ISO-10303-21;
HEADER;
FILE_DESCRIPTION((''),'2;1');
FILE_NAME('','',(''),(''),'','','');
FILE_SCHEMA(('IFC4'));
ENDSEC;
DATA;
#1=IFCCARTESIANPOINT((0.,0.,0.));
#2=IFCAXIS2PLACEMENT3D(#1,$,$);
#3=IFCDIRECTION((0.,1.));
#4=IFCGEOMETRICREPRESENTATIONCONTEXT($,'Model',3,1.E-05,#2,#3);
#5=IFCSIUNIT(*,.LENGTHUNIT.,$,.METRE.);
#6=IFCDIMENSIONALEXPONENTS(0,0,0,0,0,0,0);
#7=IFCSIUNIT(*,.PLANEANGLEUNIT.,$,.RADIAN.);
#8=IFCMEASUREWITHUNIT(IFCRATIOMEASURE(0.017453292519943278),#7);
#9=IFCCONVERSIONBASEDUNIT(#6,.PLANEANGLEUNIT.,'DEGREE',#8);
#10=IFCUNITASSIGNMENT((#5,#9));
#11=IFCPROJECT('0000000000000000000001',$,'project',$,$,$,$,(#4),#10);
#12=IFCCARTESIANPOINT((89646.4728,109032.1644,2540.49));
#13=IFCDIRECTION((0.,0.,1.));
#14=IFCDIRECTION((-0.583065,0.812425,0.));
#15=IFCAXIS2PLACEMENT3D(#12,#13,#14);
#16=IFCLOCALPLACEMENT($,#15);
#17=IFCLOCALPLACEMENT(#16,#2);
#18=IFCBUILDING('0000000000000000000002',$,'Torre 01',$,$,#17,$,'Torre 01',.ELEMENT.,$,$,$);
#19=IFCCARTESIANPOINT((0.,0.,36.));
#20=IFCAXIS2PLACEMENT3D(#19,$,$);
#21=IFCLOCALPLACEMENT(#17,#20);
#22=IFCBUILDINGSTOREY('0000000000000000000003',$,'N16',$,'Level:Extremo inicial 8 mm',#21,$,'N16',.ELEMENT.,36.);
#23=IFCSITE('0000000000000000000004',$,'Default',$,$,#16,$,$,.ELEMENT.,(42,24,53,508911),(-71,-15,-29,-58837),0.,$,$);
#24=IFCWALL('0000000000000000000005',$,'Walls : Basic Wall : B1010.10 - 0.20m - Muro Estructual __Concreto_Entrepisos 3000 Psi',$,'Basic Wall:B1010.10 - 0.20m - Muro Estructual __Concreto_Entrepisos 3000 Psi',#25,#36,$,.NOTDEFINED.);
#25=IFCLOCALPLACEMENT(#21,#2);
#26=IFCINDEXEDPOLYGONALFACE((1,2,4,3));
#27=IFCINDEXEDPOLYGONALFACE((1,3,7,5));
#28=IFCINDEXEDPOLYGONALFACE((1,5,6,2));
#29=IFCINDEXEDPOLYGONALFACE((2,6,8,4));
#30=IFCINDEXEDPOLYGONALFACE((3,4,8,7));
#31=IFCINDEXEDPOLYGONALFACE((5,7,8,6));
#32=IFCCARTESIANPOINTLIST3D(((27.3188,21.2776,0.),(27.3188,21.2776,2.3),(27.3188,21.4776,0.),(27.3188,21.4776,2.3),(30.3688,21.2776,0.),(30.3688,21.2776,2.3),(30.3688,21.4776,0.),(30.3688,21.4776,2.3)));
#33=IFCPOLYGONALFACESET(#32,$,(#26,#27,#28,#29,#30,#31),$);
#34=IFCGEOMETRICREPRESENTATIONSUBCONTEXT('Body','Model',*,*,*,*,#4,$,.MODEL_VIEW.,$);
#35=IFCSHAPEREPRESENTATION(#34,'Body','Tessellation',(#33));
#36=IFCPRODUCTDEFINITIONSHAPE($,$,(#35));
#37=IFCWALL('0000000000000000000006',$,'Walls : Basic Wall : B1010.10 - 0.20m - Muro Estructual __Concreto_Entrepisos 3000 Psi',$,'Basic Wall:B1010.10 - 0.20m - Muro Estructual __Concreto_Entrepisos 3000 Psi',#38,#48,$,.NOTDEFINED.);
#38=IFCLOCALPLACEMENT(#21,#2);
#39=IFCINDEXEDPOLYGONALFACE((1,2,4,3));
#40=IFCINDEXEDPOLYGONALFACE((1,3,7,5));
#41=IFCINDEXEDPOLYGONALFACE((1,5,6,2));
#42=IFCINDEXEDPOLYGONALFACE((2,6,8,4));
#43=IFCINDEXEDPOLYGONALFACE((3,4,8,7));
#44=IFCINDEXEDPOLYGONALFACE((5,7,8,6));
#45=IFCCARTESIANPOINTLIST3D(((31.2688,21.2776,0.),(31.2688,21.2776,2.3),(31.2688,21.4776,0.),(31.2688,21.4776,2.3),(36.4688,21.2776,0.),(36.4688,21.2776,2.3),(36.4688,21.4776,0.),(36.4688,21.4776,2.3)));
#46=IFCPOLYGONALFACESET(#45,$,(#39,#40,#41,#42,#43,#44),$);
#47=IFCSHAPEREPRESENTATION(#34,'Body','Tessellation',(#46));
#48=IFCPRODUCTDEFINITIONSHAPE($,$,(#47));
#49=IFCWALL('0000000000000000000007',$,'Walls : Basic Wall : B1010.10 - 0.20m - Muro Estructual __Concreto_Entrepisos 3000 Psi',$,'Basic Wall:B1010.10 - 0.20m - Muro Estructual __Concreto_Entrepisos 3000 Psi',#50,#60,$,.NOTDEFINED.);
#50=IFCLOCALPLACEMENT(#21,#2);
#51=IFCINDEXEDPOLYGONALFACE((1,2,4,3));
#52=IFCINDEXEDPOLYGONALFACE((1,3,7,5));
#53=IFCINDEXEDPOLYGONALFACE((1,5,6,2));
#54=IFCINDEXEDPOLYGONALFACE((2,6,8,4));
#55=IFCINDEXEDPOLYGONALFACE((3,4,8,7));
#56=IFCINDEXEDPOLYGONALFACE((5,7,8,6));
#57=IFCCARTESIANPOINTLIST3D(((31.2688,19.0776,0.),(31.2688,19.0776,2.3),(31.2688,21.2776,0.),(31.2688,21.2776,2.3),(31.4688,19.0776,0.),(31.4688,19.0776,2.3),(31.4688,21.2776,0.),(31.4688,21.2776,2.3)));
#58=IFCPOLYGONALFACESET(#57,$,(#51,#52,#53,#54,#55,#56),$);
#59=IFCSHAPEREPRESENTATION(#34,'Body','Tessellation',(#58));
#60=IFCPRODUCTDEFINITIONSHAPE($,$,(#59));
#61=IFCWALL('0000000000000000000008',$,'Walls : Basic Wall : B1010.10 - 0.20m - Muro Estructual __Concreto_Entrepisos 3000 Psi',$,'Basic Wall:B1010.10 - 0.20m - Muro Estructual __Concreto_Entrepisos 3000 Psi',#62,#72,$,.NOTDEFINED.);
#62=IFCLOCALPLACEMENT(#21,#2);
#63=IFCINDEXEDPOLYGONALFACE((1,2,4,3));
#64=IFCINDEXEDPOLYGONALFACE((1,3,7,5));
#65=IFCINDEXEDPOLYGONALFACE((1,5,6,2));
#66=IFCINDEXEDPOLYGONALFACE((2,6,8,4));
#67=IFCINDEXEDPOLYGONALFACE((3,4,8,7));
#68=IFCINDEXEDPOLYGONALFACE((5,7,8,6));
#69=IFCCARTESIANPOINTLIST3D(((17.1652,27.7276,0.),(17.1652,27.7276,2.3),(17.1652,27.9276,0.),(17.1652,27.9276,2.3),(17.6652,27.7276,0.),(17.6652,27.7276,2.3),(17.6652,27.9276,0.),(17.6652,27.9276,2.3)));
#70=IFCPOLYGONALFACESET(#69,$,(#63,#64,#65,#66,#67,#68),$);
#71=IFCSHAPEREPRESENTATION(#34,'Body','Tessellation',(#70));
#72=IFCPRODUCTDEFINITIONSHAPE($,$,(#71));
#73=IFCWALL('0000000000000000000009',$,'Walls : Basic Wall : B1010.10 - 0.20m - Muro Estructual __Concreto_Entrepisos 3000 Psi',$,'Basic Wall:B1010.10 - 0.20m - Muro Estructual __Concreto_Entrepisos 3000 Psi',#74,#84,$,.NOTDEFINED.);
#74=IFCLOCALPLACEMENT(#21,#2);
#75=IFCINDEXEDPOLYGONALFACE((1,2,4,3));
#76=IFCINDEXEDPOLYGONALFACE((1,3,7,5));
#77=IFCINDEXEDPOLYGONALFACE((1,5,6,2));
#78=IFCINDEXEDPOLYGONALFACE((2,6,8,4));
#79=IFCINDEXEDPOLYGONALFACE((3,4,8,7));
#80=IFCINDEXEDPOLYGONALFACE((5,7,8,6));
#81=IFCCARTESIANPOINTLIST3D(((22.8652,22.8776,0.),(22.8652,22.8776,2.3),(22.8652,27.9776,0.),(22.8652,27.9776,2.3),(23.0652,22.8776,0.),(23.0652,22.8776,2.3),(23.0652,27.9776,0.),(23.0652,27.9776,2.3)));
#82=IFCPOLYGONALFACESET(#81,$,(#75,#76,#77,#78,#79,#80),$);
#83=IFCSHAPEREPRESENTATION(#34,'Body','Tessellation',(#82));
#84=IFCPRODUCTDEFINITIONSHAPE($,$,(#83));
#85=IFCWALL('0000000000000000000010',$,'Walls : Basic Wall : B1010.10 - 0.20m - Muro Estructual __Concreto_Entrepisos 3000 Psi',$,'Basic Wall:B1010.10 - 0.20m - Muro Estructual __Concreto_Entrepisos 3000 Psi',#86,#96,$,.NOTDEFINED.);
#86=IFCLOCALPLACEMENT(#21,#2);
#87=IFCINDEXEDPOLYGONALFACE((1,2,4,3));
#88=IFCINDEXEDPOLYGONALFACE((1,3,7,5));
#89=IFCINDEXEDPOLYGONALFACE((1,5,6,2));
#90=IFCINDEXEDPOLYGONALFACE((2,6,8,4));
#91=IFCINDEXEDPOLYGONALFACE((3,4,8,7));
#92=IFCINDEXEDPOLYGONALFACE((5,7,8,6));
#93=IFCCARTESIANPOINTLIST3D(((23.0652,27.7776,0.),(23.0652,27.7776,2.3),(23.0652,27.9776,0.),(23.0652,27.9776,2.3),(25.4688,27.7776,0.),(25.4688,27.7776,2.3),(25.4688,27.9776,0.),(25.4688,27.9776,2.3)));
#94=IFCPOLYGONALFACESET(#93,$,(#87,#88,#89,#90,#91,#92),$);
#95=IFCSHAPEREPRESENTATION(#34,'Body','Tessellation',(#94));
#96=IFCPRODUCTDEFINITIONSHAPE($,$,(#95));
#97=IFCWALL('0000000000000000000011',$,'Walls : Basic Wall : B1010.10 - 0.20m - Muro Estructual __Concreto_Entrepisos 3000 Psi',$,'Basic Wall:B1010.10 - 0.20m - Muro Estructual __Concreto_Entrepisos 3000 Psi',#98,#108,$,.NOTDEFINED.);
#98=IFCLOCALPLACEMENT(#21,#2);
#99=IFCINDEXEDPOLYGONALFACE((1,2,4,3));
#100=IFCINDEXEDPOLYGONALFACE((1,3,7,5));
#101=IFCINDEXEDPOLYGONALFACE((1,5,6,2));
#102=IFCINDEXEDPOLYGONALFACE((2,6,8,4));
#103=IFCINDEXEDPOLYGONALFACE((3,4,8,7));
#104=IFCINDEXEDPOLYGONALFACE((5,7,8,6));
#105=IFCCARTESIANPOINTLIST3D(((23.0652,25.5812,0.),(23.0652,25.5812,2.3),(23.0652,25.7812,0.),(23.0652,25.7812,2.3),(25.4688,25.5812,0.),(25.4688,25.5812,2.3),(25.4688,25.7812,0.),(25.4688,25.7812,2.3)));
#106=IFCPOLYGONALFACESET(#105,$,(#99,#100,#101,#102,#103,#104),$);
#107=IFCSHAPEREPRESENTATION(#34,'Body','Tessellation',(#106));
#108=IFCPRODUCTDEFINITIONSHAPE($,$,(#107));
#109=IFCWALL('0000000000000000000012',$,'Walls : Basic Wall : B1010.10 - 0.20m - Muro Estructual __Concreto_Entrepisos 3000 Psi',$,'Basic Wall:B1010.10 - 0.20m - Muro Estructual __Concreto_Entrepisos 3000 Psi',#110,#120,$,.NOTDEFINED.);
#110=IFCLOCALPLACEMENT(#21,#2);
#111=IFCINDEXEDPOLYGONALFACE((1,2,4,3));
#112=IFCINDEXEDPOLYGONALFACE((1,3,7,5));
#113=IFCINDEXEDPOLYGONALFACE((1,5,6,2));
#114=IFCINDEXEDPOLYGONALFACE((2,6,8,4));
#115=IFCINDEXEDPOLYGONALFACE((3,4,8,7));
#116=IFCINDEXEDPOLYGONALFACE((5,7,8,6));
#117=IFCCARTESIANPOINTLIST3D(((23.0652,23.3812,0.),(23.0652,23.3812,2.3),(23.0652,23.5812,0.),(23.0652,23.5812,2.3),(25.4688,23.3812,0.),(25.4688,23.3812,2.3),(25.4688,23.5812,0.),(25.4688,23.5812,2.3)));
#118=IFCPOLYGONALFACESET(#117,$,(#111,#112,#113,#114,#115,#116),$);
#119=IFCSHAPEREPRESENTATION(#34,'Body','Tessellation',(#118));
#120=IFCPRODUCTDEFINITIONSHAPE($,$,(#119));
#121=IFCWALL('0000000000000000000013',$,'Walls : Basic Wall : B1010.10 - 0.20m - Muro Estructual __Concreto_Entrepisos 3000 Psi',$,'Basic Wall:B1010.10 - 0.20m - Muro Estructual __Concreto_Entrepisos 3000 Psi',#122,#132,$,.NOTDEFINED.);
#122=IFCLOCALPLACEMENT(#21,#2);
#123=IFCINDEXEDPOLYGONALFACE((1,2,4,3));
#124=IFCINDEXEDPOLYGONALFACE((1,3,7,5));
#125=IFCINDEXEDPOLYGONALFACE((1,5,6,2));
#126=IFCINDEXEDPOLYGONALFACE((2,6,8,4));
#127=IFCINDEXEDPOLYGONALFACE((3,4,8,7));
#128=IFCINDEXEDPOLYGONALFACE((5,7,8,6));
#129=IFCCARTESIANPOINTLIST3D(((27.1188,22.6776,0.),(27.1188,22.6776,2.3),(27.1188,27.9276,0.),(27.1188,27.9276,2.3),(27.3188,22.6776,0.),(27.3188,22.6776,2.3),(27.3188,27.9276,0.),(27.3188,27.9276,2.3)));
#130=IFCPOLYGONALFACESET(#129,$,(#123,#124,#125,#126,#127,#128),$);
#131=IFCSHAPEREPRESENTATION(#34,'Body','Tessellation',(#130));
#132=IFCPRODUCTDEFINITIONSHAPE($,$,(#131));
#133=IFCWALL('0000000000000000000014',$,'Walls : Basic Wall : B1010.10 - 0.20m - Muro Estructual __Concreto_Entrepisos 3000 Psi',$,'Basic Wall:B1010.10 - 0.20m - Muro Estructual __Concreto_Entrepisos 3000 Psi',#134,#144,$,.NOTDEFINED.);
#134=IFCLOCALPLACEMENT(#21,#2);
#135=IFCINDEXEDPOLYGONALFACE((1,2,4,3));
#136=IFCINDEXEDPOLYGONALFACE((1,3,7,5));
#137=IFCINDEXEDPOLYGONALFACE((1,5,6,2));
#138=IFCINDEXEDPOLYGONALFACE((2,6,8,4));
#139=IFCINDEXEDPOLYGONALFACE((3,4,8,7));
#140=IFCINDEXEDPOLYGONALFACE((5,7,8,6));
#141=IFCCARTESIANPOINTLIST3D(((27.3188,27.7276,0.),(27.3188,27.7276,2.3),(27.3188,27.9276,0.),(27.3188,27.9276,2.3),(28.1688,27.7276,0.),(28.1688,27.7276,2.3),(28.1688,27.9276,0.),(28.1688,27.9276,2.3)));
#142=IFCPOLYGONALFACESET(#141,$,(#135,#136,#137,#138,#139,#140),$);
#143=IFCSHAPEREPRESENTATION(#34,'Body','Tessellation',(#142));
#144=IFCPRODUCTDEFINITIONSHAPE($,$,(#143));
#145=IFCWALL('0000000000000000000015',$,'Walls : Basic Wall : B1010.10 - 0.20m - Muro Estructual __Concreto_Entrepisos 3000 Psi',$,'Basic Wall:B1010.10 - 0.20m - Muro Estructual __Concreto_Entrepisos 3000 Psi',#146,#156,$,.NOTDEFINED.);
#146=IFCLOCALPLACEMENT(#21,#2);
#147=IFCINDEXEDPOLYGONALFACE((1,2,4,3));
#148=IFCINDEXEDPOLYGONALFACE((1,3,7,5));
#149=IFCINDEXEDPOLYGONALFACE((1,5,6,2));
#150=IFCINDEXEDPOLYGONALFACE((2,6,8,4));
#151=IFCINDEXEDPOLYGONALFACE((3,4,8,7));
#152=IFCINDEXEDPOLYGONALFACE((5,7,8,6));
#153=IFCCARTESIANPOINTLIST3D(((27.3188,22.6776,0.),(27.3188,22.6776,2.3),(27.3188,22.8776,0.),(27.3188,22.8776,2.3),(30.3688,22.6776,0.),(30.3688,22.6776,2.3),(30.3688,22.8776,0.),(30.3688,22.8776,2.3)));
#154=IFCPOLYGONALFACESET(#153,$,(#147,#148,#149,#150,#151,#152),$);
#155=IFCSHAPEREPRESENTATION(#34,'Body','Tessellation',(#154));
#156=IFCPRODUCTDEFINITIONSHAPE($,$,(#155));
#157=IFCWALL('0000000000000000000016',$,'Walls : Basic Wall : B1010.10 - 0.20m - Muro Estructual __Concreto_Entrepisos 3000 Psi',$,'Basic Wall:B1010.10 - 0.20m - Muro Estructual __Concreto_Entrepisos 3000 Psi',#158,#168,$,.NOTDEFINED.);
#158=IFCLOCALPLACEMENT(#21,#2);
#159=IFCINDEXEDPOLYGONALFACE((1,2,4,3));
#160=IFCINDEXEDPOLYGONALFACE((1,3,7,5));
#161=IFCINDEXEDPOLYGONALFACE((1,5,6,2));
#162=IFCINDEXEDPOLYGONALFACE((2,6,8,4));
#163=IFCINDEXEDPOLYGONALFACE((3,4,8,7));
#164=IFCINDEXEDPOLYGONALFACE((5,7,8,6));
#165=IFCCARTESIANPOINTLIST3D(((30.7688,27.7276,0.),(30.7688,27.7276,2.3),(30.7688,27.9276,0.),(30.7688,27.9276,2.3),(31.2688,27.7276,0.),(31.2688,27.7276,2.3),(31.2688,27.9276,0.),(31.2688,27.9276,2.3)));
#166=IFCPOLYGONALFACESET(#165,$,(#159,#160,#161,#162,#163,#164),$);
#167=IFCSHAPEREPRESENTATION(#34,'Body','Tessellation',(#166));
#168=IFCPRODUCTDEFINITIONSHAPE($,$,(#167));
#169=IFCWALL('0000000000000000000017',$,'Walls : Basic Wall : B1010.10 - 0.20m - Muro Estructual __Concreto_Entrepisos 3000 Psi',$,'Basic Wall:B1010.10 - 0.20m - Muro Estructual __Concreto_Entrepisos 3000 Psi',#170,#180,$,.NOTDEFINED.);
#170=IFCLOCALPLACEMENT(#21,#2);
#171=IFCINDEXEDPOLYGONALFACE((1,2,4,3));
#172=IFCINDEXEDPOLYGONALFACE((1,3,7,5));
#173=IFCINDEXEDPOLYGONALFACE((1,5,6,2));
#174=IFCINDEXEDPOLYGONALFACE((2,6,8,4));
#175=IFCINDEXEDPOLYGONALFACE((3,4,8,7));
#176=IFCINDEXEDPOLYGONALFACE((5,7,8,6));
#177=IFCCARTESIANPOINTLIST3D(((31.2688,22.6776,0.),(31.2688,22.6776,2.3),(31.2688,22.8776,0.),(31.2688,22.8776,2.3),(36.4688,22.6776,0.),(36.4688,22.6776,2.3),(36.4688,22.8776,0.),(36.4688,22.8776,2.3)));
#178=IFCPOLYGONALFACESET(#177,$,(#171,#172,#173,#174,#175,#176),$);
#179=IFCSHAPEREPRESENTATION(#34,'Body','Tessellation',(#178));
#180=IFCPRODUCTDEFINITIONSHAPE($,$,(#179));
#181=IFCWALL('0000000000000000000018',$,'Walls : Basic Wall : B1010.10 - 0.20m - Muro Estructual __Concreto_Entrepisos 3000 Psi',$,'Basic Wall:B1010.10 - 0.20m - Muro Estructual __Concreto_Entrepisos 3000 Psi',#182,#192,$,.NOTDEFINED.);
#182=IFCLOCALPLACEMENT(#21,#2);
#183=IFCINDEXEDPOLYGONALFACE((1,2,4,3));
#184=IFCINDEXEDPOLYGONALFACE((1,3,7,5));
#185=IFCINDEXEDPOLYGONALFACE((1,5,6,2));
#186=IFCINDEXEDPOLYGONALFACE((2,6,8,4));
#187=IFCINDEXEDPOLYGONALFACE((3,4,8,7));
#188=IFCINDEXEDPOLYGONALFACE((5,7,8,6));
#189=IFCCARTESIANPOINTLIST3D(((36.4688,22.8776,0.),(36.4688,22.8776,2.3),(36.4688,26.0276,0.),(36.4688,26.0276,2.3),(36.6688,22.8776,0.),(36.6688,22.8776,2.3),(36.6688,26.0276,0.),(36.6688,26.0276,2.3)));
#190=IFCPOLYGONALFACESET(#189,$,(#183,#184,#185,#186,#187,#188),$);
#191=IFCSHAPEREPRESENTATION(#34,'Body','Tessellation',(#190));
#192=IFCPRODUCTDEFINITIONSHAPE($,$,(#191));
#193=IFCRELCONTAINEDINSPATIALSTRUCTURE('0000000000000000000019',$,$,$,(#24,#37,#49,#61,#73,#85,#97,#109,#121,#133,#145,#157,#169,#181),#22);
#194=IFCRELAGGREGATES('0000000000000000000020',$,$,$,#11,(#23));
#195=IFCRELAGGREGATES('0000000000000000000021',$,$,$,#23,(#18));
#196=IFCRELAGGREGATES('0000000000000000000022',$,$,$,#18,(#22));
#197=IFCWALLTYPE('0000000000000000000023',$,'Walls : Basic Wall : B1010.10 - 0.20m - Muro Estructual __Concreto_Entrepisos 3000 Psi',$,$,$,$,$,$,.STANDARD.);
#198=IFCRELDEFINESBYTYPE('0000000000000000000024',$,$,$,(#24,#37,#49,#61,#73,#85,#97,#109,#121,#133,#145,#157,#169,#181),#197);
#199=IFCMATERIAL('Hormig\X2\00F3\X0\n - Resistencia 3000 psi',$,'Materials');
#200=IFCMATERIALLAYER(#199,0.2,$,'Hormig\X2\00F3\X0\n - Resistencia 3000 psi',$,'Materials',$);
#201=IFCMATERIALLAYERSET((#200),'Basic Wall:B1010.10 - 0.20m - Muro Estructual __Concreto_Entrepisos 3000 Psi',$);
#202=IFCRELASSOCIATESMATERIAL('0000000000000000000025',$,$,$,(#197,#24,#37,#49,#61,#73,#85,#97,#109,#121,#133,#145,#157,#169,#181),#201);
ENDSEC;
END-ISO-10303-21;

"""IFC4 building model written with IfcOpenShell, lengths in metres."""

from ifc_helpers import new_model, entity, si_unit, converted_unit, direction, frame, frame_2d, origin, place, context, subcontext, project, spatial, rectangle, extrude, material, layer, layer_set, layer_usage, type_object, element, save


model = new_model("IFC4")

# Units and contexts
model_context = context("Model", 3, precision=1e-05, world=origin(), true_north=direction((0.0, 1.0)))
body_context = subcontext(model_context, "Body", "Model", "MODEL_VIEW")
ifc_project = project(units=[si_unit("LENGTHUNIT", "METRE"), converted_unit("PLANEANGLEUNIT", "DEGREE", entity("IfcRatioMeasure", 0.017453292519943278), si_unit("PLANEANGLEUNIT", "RADIAN"), dimensions=[0, 0, 0, 0, 0, 0, 0])], contexts=[model_context])

# Site, building, storey
site_placement = place(None, frame((89646.4728, 109032.1644, 2540.49), z_axis=(0.0, 0.0, 1.0), x_axis=(-0.583065, 0.812425, 0.0)))
site = spatial("IfcSite", under=ifc_project, at=site_placement, Name="Default", CompositionType="ELEMENT", RefLatitude=(42, 24, 53, 508911), RefLongitude=(-71, -15, -29, -58837), RefElevation=0.0)
building_placement = place(site_placement, origin())
building = spatial("IfcBuilding", under=site, at=building_placement, Name="Torre 01", LongName="Torre 01", CompositionType="ELEMENT")
storey_placement = place(building_placement, frame((0.0, 0.0, 36.0)))
storey = spatial("IfcBuildingStorey", under=building, at=storey_placement, Name="N16", ObjectType="Level:Extremo inicial 8 mm", LongName="N16", CompositionType="ELEMENT", Elevation=36.0)

# Walls
ifc_material = material(Name="Hormigón - Resistencia 3000 psi", Category="Materials")
ifc_layer_1 = layer(ifc_material, 0.2, Name="Hormigón - Resistencia 3000 psi", Category="Materials")
ifc_layer_set_1 = layer_set([ifc_layer_1], Name="Basic Wall:B1010.10 - 0.20m - Muro Estructual __Concreto_Entrepisos 3000 Psi")
ifc_layer_usage_1 = layer_usage(ifc_layer_set_1, "AXIS2", "NEGATIVE", 0.1)
wall_type_1 = type_object("IfcWallType", Name="Walls : Basic Wall : B1010.10 - 0.20m - Muro Estructual __Concreto_Entrepisos 3000 Psi", PredefinedType="STANDARD", material=ifc_layer_set_1)
wall_1_placement = place(storey_placement, frame((27.3188, 21.3776, 0.0)))
element("IfcWall", 1, at=wall_1_placement, inside=storey, type_object=wall_type_1, material=ifc_layer_usage_1, Name="Walls : Basic Wall : B1010.10 - 0.20m - Muro Estructual __Concreto_Entrepisos 3000 Psi", ObjectType="Basic Wall:B1010.10 - 0.20m - Muro Estructual __Concreto_Entrepisos 3000 Psi", PredefinedType="NOTDEFINED", context=body_context, shape_type="SweptSolid", body=[
    extrude(rectangle(XDim=3.05, YDim=0.2, at=frame_2d((1.525, 0.0), x_axis=(-1.0, 0.0))), origin(), (0.0, 0.0, 1.0), 2.3),
])
ifc_layer_usage_2 = layer_usage(ifc_layer_set_1, "AXIS2", "NEGATIVE", 0.1)
wall_2_placement = place(storey_placement, frame((31.2688, 21.3776, 0.0)))
element("IfcWall", 2, at=wall_2_placement, inside=storey, type_object=wall_type_1, material=ifc_layer_usage_2, Name="Walls : Basic Wall : B1010.10 - 0.20m - Muro Estructual __Concreto_Entrepisos 3000 Psi", ObjectType="Basic Wall:B1010.10 - 0.20m - Muro Estructual __Concreto_Entrepisos 3000 Psi", PredefinedType="NOTDEFINED", context=body_context, shape_type="SweptSolid", body=[
    extrude(rectangle(XDim=5.2, YDim=0.2, at=frame_2d((2.6, 0.0), x_axis=(-1.0, 0.0))), origin(), (0.0, 0.0, 1.0), 2.3),
])
ifc_layer_usage_3 = layer_usage(ifc_layer_set_1, "AXIS2", "NEGATIVE", 0.1)
wall_3_placement = place(storey_placement, frame((31.3688, 21.2776, 0.0), z_axis=(0.0, 0.0, 1.0), x_axis=(0.0, -1.0, 0.0)))
element("IfcWall", 3, at=wall_3_placement, inside=storey, type_object=wall_type_1, material=ifc_layer_usage_3, Name="Walls : Basic Wall : B1010.10 - 0.20m - Muro Estructual __Concreto_Entrepisos 3000 Psi", ObjectType="Basic Wall:B1010.10 - 0.20m - Muro Estructual __Concreto_Entrepisos 3000 Psi", PredefinedType="NOTDEFINED", context=body_context, shape_type="SweptSolid", body=[
    extrude(rectangle(XDim=2.2, YDim=0.2, at=frame_2d((1.1, 0.0), x_axis=(-1.0, 0.0))), origin(), (0.0, 0.0, 1.0), 2.3),
])
ifc_layer_usage_4 = layer_usage(ifc_layer_set_1, "AXIS2", "POSITIVE", -0.1)
wall_4_placement = place(storey_placement, frame((17.6652, 27.8276, 0.0), z_axis=(0.0, 0.0, 1.0), x_axis=(-1.0, 0.0, 0.0)))
element("IfcWall", 4, at=wall_4_placement, inside=storey, type_object=wall_type_1, material=ifc_layer_usage_4, Name="Walls : Basic Wall : B1010.10 - 0.20m - Muro Estructual __Concreto_Entrepisos 3000 Psi", ObjectType="Basic Wall:B1010.10 - 0.20m - Muro Estructual __Concreto_Entrepisos 3000 Psi", PredefinedType="NOTDEFINED", context=body_context, shape_type="SweptSolid", body=[
    extrude(rectangle(XDim=0.5, YDim=0.2, at=frame_2d((0.25, 0.0), x_axis=(-1.0, 0.0))), origin(), (0.0, 0.0, 1.0), 2.3),
])
ifc_layer_usage_5 = layer_usage(ifc_layer_set_1, "AXIS2", "NEGATIVE", 0.1)
wall_5_placement = place(storey_placement, frame((22.9652, 22.8776, 0.0), z_axis=(0.0, 0.0, 1.0), x_axis=(0.0, 1.0, 0.0)))
element("IfcWall", 5, at=wall_5_placement, inside=storey, type_object=wall_type_1, material=ifc_layer_usage_5, Name="Walls : Basic Wall : B1010.10 - 0.20m - Muro Estructual __Concreto_Entrepisos 3000 Psi", ObjectType="Basic Wall:B1010.10 - 0.20m - Muro Estructual __Concreto_Entrepisos 3000 Psi", PredefinedType="NOTDEFINED", context=body_context, shape_type="SweptSolid", body=[
    extrude(rectangle(XDim=5.1, YDim=0.2, at=frame_2d((2.55, 0.0), x_axis=(-1.0, 0.0))), origin(), (0.0, 0.0, 1.0), 2.3),
])
ifc_layer_usage_6 = layer_usage(ifc_layer_set_1, "AXIS2", "NEGATIVE", 0.1)
wall_6_placement = place(storey_placement, frame((23.0652, 27.8776, 0.0)))
element("IfcWall", 6, at=wall_6_placement, inside=storey, type_object=wall_type_1, material=ifc_layer_usage_6, Name="Walls : Basic Wall : B1010.10 - 0.20m - Muro Estructual __Concreto_Entrepisos 3000 Psi", ObjectType="Basic Wall:B1010.10 - 0.20m - Muro Estructual __Concreto_Entrepisos 3000 Psi", PredefinedType="NOTDEFINED", context=body_context, shape_type="SweptSolid", body=[
    extrude(rectangle(XDim=2.4037, YDim=0.2, at=frame_2d((1.2018, 0.0), x_axis=(-1.0, 0.0))), origin(), (0.0, 0.0, 1.0), 2.3),
])
ifc_layer_usage_7 = layer_usage(ifc_layer_set_1, "AXIS2", "NEGATIVE", 0.1)
wall_7_placement = place(storey_placement, frame((23.0652, 25.6812, 0.0)))
element("IfcWall", 7, at=wall_7_placement, inside=storey, type_object=wall_type_1, material=ifc_layer_usage_7, Name="Walls : Basic Wall : B1010.10 - 0.20m - Muro Estructual __Concreto_Entrepisos 3000 Psi", ObjectType="Basic Wall:B1010.10 - 0.20m - Muro Estructual __Concreto_Entrepisos 3000 Psi", PredefinedType="NOTDEFINED", context=body_context, shape_type="SweptSolid", body=[
    extrude(rectangle(XDim=2.4037, YDim=0.2, at=frame_2d((1.2018, 0.0), x_axis=(-1.0, 0.0))), origin(), (0.0, 0.0, 1.0), 2.3),
])
ifc_layer_usage_8 = layer_usage(ifc_layer_set_1, "AXIS2", "NEGATIVE", 0.1)
wall_8_placement = place(storey_placement, frame((23.0652, 23.4812, 0.0)))
element("IfcWall", 8, at=wall_8_placement, inside=storey, type_object=wall_type_1, material=ifc_layer_usage_8, Name="Walls : Basic Wall : B1010.10 - 0.20m - Muro Estructual __Concreto_Entrepisos 3000 Psi", ObjectType="Basic Wall:B1010.10 - 0.20m - Muro Estructual __Concreto_Entrepisos 3000 Psi", PredefinedType="NOTDEFINED", context=body_context, shape_type="SweptSolid", body=[
    extrude(rectangle(XDim=2.4037, YDim=0.2, at=frame_2d((1.2018, 0.0), x_axis=(-1.0, 0.0))), origin(), (0.0, 0.0, 1.0), 2.3),
])
ifc_layer_usage_9 = layer_usage(ifc_layer_set_1, "AXIS2", "POSITIVE", -0.1)
wall_9_placement = place(storey_placement, frame((27.2188, 27.9276, 0.0), z_axis=(0.0, 0.0, 1.0), x_axis=(0.0, -1.0, 0.0)))
element("IfcWall", 9, at=wall_9_placement, inside=storey, type_object=wall_type_1, material=ifc_layer_usage_9, Name="Walls : Basic Wall : B1010.10 - 0.20m - Muro Estructual __Concreto_Entrepisos 3000 Psi", ObjectType="Basic Wall:B1010.10 - 0.20m - Muro Estructual __Concreto_Entrepisos 3000 Psi", PredefinedType="NOTDEFINED", context=body_context, shape_type="SweptSolid", body=[
    extrude(rectangle(XDim=5.25, YDim=0.2, at=frame_2d((2.625, 0.0), x_axis=(-1.0, 0.0))), origin(), (0.0, 0.0, 1.0), 2.3),
])
ifc_layer_usage_10 = layer_usage(ifc_layer_set_1, "AXIS2", "POSITIVE", -0.1)
wall_10_placement = place(storey_placement, frame((27.3188, 27.8276, 0.0)))
element("IfcWall", 10, at=wall_10_placement, inside=storey, type_object=wall_type_1, material=ifc_layer_usage_10, Name="Walls : Basic Wall : B1010.10 - 0.20m - Muro Estructual __Concreto_Entrepisos 3000 Psi", ObjectType="Basic Wall:B1010.10 - 0.20m - Muro Estructual __Concreto_Entrepisos 3000 Psi", PredefinedType="NOTDEFINED", context=body_context, shape_type="SweptSolid", body=[
    extrude(rectangle(XDim=0.85, YDim=0.2, at=frame_2d((0.425, 0.0), x_axis=(-1.0, 0.0))), origin(), (0.0, 0.0, 1.0), 2.3),
])
ifc_layer_usage_11 = layer_usage(ifc_layer_set_1, "AXIS2", "POSITIVE", -0.1)
wall_11_placement = place(storey_placement, frame((27.3188, 22.7776, 0.0)))
element("IfcWall", 11, at=wall_11_placement, inside=storey, type_object=wall_type_1, material=ifc_layer_usage_11, Name="Walls : Basic Wall : B1010.10 - 0.20m - Muro Estructual __Concreto_Entrepisos 3000 Psi", ObjectType="Basic Wall:B1010.10 - 0.20m - Muro Estructual __Concreto_Entrepisos 3000 Psi", PredefinedType="NOTDEFINED", context=body_context, shape_type="SweptSolid", body=[
    extrude(rectangle(XDim=3.05, YDim=0.2, at=frame_2d((1.525, 0.0), x_axis=(-1.0, 0.0))), origin(), (0.0, 0.0, 1.0), 2.3),
])
ifc_layer_usage_12 = layer_usage(ifc_layer_set_1, "AXIS2", "POSITIVE", -0.1)
wall_12_placement = place(storey_placement, frame((30.7688, 27.8276, 0.0)))
element("IfcWall", 12, at=wall_12_placement, inside=storey, type_object=wall_type_1, material=ifc_layer_usage_12, Name="Walls : Basic Wall : B1010.10 - 0.20m - Muro Estructual __Concreto_Entrepisos 3000 Psi", ObjectType="Basic Wall:B1010.10 - 0.20m - Muro Estructual __Concreto_Entrepisos 3000 Psi", PredefinedType="NOTDEFINED", context=body_context, shape_type="SweptSolid", body=[
    extrude(rectangle(XDim=0.5, YDim=0.2, at=frame_2d((0.25, 0.0), x_axis=(-1.0, 0.0))), origin(), (0.0, 0.0, 1.0), 2.3),
])
ifc_layer_usage_13 = layer_usage(ifc_layer_set_1, "AXIS2", "POSITIVE", -0.1)
wall_13_placement = place(storey_placement, frame((31.2688, 22.7776, 0.0)))
element("IfcWall", 13, at=wall_13_placement, inside=storey, type_object=wall_type_1, material=ifc_layer_usage_13, Name="Walls : Basic Wall : B1010.10 - 0.20m - Muro Estructual __Concreto_Entrepisos 3000 Psi", ObjectType="Basic Wall:B1010.10 - 0.20m - Muro Estructual __Concreto_Entrepisos 3000 Psi", PredefinedType="NOTDEFINED", context=body_context, shape_type="SweptSolid", body=[
    extrude(rectangle(XDim=5.2, YDim=0.2, at=frame_2d((2.6, 0.0), x_axis=(-1.0, 0.0))), origin(), (0.0, 0.0, 1.0), 2.3),
])
ifc_layer_usage_14 = layer_usage(ifc_layer_set_1, "AXIS2", "POSITIVE", -0.1)
wall_14_placement = place(storey_placement, frame((36.5688, 26.0276, 0.0), z_axis=(0.0, 0.0, 1.0), x_axis=(0.0, -1.0, 0.0)))
element("IfcWall", 14, at=wall_14_placement, inside=storey, type_object=wall_type_1, material=ifc_layer_usage_14, Name="Walls : Basic Wall : B1010.10 - 0.20m - Muro Estructual __Concreto_Entrepisos 3000 Psi", ObjectType="Basic Wall:B1010.10 - 0.20m - Muro Estructual __Concreto_Entrepisos 3000 Psi", PredefinedType="NOTDEFINED", context=body_context, shape_type="SweptSolid", body=[
    extrude(rectangle(XDim=3.15, YDim=0.2, at=frame_2d((1.575, 0.0), x_axis=(-1.0, 0.0))), origin(), (0.0, 0.0, 1.0), 2.3),
])

save(model, "model.ifc")
